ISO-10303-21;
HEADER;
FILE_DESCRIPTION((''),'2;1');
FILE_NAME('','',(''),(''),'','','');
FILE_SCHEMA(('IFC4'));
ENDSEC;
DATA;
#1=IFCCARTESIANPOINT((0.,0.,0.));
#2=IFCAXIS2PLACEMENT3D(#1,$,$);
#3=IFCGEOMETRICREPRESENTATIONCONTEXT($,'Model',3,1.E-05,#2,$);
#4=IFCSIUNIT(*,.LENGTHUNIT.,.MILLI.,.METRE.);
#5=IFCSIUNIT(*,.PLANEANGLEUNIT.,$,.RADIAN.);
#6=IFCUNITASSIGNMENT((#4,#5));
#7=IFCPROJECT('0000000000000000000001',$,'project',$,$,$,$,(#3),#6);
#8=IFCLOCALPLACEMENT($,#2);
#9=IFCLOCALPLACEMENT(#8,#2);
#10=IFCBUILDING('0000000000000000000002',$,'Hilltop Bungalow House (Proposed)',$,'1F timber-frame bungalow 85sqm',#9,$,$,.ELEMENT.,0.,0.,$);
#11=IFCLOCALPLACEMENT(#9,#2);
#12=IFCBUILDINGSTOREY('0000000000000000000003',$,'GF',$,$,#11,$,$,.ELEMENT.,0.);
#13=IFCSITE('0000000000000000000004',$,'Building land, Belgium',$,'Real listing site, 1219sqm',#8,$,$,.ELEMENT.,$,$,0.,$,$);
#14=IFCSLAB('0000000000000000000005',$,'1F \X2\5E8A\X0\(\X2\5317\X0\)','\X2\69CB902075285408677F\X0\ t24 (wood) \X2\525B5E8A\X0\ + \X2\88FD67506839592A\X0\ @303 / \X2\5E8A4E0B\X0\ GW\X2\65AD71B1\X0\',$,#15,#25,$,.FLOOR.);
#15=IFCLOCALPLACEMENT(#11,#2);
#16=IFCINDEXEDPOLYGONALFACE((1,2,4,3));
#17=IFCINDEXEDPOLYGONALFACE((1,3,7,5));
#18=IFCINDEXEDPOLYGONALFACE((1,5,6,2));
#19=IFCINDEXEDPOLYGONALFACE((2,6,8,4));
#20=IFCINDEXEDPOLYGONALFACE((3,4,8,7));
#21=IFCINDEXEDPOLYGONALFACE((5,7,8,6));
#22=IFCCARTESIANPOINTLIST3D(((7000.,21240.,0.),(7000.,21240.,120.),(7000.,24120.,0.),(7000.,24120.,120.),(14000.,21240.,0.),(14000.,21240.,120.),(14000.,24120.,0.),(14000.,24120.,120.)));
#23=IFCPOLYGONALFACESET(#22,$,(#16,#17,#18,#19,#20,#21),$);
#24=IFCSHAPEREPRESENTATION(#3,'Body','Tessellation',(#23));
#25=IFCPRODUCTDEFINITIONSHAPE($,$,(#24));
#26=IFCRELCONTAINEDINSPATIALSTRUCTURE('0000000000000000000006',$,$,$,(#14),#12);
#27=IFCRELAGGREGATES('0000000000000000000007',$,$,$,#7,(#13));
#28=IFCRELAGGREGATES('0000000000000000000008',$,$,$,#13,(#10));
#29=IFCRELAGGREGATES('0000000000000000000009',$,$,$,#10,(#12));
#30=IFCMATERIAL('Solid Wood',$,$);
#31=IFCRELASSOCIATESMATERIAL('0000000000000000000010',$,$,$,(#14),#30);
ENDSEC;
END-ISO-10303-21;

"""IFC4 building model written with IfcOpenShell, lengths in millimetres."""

from ifc_helpers import new_model, si_unit, frame, frame_2d, origin, place, context, project, spatial, rectangle, extrude, material, element, save


model = new_model("IFC4")

# Units and contexts
model_context = context("Model", 3, precision=1e-05, world=origin())
ifc_project = project(units=[si_unit("LENGTHUNIT", "METRE", prefix="MILLI"), si_unit("PLANEANGLEUNIT", "RADIAN")], contexts=[model_context])

# Site, building, storey
site_placement = place(None, origin())
site = spatial("IfcSite", under=ifc_project, at=site_placement, Name="Building land, Belgium", ObjectType="Real listing site, 1219sqm", CompositionType="ELEMENT", RefElevation=0.0)
building_placement = place(site_placement, origin())
building = spatial("IfcBuilding", under=site, at=building_placement, Name="Hilltop Bungalow House (Proposed)", ObjectType="1F timber-frame bungalow 85sqm", CompositionType="ELEMENT", ElevationOfRefHeight=0.0, ElevationOfTerrain=0.0)
storey_placement = place(building_placement, origin())
storey = spatial("IfcBuildingStorey", under=building, at=storey_placement, Name="GF", CompositionType="ELEMENT", Elevation=0.0)

# Slab
ifc_material_1 = material(Name="Solid Wood")
slab_1_placement = place(storey_placement, frame((3500.0, 10620.0, 0.0)))
element("IfcSlab", 1, at=slab_1_placement, inside=storey, material=ifc_material_1, Name="1F 床(北)", Description="構造用合板 t24 (wood) 剛床 + 製材根太 @303 / 床下 GW断熱", PredefinedType="FLOOR", context=model_context, shape_type="SweptSolid", body=[
    extrude(rectangle(XDim=7000.0, YDim=2880.0, at=frame_2d((3500.0, 1440.0))), frame((3500.0, 10620.0, 0.0)), (0.0, 0.0, 1.0), 120.0),
])

save(model, "model.ifc")
